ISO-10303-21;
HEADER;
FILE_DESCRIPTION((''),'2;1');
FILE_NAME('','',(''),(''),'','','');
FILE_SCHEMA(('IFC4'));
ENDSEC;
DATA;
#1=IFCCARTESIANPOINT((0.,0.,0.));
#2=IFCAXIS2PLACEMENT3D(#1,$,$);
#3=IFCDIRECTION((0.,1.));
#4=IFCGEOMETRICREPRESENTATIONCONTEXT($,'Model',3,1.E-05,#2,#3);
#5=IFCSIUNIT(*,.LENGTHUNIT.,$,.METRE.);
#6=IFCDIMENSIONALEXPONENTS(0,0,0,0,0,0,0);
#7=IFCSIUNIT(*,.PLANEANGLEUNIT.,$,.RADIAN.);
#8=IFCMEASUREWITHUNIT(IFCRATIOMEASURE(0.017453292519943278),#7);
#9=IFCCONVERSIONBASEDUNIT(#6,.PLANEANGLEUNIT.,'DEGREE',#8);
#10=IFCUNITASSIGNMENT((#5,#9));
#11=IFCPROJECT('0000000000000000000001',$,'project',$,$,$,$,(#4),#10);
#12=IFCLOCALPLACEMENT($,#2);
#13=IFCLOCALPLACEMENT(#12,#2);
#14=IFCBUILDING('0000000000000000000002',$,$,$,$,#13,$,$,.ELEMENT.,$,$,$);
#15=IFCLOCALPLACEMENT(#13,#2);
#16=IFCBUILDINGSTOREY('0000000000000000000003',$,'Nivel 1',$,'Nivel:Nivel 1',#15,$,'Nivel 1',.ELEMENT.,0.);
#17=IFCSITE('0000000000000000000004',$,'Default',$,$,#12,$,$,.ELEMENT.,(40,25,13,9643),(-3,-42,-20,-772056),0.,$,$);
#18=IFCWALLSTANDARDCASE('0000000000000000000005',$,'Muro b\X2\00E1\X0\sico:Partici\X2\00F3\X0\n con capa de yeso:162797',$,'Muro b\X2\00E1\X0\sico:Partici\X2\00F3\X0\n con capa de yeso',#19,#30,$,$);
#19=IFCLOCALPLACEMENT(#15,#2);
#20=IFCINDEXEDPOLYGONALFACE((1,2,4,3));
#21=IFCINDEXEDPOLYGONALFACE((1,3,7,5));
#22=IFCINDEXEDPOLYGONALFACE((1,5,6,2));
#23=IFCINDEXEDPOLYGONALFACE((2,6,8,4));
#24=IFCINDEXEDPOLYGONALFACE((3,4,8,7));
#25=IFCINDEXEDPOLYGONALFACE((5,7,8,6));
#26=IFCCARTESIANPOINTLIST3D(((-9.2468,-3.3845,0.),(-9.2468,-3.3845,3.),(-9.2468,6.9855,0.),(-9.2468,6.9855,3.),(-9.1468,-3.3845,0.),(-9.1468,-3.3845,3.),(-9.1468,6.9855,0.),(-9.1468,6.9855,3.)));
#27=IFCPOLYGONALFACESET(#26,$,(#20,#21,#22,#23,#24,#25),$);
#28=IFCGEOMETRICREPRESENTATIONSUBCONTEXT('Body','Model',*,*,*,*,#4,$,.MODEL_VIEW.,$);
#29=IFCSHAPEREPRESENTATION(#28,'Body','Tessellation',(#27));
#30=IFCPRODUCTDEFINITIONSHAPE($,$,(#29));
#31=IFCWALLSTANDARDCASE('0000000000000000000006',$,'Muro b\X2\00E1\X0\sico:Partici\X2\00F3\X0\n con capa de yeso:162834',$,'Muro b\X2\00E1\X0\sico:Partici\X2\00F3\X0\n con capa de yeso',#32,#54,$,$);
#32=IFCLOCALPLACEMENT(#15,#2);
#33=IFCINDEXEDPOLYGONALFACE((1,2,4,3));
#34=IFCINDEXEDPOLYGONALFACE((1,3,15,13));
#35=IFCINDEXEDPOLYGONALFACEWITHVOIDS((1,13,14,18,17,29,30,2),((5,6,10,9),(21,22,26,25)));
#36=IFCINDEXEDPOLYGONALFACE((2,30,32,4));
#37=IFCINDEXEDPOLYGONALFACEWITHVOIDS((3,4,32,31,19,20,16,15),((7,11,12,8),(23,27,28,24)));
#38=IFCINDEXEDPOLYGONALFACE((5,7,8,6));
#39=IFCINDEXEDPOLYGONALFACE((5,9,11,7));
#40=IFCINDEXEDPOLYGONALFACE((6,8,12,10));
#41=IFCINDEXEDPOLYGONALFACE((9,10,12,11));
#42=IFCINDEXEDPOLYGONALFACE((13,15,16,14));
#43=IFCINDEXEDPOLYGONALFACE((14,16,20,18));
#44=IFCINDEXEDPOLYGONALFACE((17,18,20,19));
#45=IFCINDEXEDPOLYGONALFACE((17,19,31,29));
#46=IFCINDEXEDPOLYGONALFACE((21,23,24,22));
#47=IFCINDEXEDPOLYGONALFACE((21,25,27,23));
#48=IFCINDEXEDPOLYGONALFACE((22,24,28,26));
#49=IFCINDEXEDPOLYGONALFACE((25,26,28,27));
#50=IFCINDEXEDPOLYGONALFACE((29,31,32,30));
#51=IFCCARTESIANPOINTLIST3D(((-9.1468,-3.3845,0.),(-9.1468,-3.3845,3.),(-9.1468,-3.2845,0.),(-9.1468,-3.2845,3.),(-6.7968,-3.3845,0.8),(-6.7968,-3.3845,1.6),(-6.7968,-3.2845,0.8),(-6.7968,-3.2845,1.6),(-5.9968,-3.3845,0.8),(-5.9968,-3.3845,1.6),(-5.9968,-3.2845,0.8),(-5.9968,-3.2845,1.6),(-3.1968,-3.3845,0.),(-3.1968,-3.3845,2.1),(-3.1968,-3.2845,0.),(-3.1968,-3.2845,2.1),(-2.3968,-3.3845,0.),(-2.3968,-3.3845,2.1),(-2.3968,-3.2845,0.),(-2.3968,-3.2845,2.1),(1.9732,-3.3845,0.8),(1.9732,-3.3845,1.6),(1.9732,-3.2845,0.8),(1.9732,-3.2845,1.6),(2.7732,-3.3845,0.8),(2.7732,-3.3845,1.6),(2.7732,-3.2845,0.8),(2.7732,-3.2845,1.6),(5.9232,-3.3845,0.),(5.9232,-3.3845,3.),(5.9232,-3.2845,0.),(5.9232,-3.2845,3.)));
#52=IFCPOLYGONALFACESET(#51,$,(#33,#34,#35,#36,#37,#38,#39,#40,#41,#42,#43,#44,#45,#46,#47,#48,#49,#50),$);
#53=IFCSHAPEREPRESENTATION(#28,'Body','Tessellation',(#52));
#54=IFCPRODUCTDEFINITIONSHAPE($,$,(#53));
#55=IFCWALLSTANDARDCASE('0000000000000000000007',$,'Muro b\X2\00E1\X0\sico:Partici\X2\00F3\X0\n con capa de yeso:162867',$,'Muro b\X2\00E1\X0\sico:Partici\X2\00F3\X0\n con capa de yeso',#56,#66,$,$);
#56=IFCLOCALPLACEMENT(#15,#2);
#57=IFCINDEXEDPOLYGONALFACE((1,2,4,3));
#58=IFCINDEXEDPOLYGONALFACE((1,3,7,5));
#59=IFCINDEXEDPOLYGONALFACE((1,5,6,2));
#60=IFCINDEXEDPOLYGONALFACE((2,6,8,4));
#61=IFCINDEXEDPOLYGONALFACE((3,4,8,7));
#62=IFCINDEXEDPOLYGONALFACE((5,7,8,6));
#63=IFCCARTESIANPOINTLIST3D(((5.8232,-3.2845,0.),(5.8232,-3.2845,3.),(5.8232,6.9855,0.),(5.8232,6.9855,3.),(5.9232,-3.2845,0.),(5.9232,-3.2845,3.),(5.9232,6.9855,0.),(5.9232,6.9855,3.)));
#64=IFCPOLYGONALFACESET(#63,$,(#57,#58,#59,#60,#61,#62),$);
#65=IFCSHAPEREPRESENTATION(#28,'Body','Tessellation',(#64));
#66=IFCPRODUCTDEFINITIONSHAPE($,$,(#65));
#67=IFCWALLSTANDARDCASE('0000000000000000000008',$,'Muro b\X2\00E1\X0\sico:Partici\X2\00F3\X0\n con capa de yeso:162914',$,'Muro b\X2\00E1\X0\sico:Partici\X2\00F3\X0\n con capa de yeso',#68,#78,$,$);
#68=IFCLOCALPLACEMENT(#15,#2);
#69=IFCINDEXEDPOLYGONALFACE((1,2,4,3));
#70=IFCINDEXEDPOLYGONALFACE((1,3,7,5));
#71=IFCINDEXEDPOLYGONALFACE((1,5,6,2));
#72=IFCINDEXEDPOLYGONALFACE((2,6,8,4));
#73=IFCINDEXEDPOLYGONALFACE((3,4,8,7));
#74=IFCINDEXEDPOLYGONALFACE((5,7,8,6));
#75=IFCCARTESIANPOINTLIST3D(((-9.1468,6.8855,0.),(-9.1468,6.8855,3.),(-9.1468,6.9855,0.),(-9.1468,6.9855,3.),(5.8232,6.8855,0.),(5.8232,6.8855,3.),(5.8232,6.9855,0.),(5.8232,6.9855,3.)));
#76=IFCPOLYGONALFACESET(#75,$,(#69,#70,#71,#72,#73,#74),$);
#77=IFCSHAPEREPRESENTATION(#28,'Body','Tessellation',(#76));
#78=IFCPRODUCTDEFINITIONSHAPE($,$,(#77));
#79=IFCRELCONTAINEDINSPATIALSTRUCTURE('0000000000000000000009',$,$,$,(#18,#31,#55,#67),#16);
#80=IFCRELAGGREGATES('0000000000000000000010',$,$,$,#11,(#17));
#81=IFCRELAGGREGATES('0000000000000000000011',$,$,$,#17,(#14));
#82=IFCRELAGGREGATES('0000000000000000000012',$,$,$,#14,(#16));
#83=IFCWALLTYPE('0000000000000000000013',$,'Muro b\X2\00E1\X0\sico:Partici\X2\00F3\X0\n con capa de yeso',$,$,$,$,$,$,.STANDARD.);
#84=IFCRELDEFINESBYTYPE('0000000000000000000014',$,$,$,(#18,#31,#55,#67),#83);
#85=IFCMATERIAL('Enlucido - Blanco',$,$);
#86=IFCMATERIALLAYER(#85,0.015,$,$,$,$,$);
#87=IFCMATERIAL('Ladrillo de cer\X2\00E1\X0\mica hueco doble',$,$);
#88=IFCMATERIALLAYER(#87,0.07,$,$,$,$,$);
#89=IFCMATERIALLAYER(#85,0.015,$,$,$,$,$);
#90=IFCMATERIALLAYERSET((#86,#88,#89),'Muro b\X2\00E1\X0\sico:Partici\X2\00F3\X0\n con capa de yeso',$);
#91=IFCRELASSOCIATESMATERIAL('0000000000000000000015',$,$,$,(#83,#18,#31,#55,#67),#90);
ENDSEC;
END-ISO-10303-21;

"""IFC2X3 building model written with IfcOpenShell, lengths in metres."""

from ifc_helpers import new_model, entity, si_unit, converted_unit, direction, frame, frame_2d, origin, place, context, subcontext, project, spatial, rectangle, extrude, material, layer, layer_set, layer_usage, type_object, element, save


model = new_model("IFC2X3")

# Units and contexts
model_context = context("Model", 3, precision=1e-05, world=origin(), true_north=direction((0.0, 1.0)))
body_context = subcontext(model_context, "Body", "Model", "MODEL_VIEW")
ifc_project = project(units=[si_unit("LENGTHUNIT", "METRE"), converted_unit("PLANEANGLEUNIT", "DEGREE", entity("IfcRatioMeasure", 0.017453292519943278), si_unit("PLANEANGLEUNIT", "RADIAN"), dimensions=[0, 0, 0, 0, 0, 0, 0])], contexts=[model_context])

# Site, building, storey
site_placement = place(None, origin())
site = spatial("IfcSite", under=ifc_project, at=site_placement, Name="Default", CompositionType="ELEMENT", RefLatitude=(40, 25, 13, 9643), RefLongitude=(-3, -42, -20, -772056), RefElevation=0.0)
building_placement = place(site_placement, origin())
building = spatial("IfcBuilding", under=site, at=building_placement, CompositionType="ELEMENT")
storey_placement = place(building_placement, origin())
storey = spatial("IfcBuildingStorey", under=building, at=storey_placement, Name="Nivel 1", ObjectType="Nivel:Nivel 1", LongName="Nivel 1", CompositionType="ELEMENT", Elevation=0.0)

# Wall
ifc_material_1 = material(Name="Enlucido - Blanco")
ifc_layer_1 = layer(ifc_material_1, 0.015)
ifc_material_2 = material(Name="Ladrillo de cerámica hueco doble")
ifc_layer_2 = layer(ifc_material_2, 0.07)
ifc_layer_3 = layer(ifc_material_1, 0.015)
ifc_layer_set = layer_set([ifc_layer_1, ifc_layer_2, ifc_layer_3], Name="Muro básico:Partición con capa de yeso")
ifc_layer_usage = layer_usage(ifc_layer_set, "AXIS2", "NEGATIVE", 0.05)
wall_type = type_object("IfcWallType", Name="Muro básico:Partición con capa de yeso", PredefinedType="STANDARD", material=ifc_layer_set)
wall_1_placement = place(storey_placement, frame((-9.1968, 6.9855, 0.0), z_axis=(0.0, 0.0, 1.0), x_axis=(0.0, -1.0, 0.0)))
element("IfcWallStandardCase", 1, at=wall_1_placement, inside=storey, type_object=wall_type, material=ifc_layer_usage, Name="Muro básico:Partición con capa de yeso:162797", ObjectType="Muro básico:Partición con capa de yeso", context=body_context, shape_type="SweptSolid", body=[
    extrude(rectangle(XDim=10.37, YDim=0.1, at=frame_2d((5.185, 0.0), x_axis=(-1.0, 0.0))), origin(), (0.0, 0.0, 1.0), 3.0),
])

# Wall, openings
wall_2_placement = place(storey_placement, frame((-9.1468, -3.3345, 0.0)))
wall_2 = element("IfcWallStandardCase", 2, at=wall_2_placement, inside=storey, type_object=wall_type, material=ifc_layer_usage, Name="Muro básico:Partición con capa de yeso:162834", ObjectType="Muro básico:Partición con capa de yeso", context=body_context, shape_type="SweptSolid", body=[
    extrude(rectangle(XDim=15.07, YDim=0.1, at=frame_2d((7.535, 0.0), x_axis=(-1.0, 0.0))), origin(), (0.0, 0.0, 1.0), 3.0),
])
opening_1_placement = place(wall_2_placement, frame((6.75, 0.05, 0.0)))
element("IfcOpeningElement", 3, at=opening_1_placement, cuts=wall_2, ObjectType="Opening", context=body_context, shape_type="SweptSolid", body=[
    extrude(rectangle(XDim=2.1, YDim=0.8, at=frame_2d((1.05, 0.4), x_axis=(1.0, 0.0))), frame((0.0, 0.0, 0.0), z_axis=(0.0, -1.0, 0.0), x_axis=(0.0, 0.0, 1.0)), (0.0, 0.0, 1.0), 0.1),
])
opening_2_placement = place(wall_2_placement, frame((3.15, 0.05, 0.8)))
element("IfcOpeningElement", 4, at=opening_2_placement, cuts=wall_2, ObjectType="Opening", context=body_context, shape_type="SweptSolid", body=[
    extrude(rectangle(XDim=0.8, YDim=0.8, at=frame_2d((0.4, 0.4), x_axis=(1.0, 0.0))), frame((0.0, 0.0, 0.0), z_axis=(0.0, -1.0, 0.0), x_axis=(0.0, 0.0, 1.0)), (0.0, 0.0, 1.0), 0.1),
])
opening_3_placement = place(wall_2_placement, frame((11.92, 0.05, 0.8)))
element("IfcOpeningElement", 5, at=opening_3_placement, cuts=wall_2, ObjectType="Opening", context=body_context, shape_type="SweptSolid", body=[
    extrude(rectangle(XDim=0.8, YDim=0.8, at=frame_2d((0.4, 0.4), x_axis=(1.0, 0.0))), frame((0.0, 0.0, 0.0), z_axis=(0.0, -1.0, 0.0), x_axis=(0.0, 0.0, 1.0)), (0.0, 0.0, 1.0), 0.1),
])

# Walls
wall_3_placement = place(storey_placement, frame((5.8732, -3.2845, 0.0), z_axis=(0.0, 0.0, 1.0), x_axis=(0.0, 1.0, 0.0)))
element("IfcWallStandardCase", 6, at=wall_3_placement, inside=storey, type_object=wall_type, material=ifc_layer_usage, Name="Muro básico:Partición con capa de yeso:162867", ObjectType="Muro básico:Partición con capa de yeso", context=body_context, shape_type="SweptSolid", body=[
    extrude(rectangle(XDim=10.27, YDim=0.1, at=frame_2d((5.135, 0.0), x_axis=(-1.0, 0.0))), origin(), (0.0, 0.0, 1.0), 3.0),
])
wall_4_placement = place(storey_placement, frame((5.8232, 6.9355, 0.0), z_axis=(0.0, 0.0, 1.0), x_axis=(-1.0, 0.0, 0.0)))
element("IfcWallStandardCase", 7, at=wall_4_placement, inside=storey, type_object=wall_type, material=ifc_layer_usage, Name="Muro básico:Partición con capa de yeso:162914", ObjectType="Muro básico:Partición con capa de yeso", context=body_context, shape_type="SweptSolid", body=[
    extrude(rectangle(XDim=14.97, YDim=0.1, at=frame_2d((7.485, 0.0), x_axis=(-1.0, 0.0))), origin(), (0.0, 0.0, 1.0), 3.0),
])

save(model, "model.ifc")
